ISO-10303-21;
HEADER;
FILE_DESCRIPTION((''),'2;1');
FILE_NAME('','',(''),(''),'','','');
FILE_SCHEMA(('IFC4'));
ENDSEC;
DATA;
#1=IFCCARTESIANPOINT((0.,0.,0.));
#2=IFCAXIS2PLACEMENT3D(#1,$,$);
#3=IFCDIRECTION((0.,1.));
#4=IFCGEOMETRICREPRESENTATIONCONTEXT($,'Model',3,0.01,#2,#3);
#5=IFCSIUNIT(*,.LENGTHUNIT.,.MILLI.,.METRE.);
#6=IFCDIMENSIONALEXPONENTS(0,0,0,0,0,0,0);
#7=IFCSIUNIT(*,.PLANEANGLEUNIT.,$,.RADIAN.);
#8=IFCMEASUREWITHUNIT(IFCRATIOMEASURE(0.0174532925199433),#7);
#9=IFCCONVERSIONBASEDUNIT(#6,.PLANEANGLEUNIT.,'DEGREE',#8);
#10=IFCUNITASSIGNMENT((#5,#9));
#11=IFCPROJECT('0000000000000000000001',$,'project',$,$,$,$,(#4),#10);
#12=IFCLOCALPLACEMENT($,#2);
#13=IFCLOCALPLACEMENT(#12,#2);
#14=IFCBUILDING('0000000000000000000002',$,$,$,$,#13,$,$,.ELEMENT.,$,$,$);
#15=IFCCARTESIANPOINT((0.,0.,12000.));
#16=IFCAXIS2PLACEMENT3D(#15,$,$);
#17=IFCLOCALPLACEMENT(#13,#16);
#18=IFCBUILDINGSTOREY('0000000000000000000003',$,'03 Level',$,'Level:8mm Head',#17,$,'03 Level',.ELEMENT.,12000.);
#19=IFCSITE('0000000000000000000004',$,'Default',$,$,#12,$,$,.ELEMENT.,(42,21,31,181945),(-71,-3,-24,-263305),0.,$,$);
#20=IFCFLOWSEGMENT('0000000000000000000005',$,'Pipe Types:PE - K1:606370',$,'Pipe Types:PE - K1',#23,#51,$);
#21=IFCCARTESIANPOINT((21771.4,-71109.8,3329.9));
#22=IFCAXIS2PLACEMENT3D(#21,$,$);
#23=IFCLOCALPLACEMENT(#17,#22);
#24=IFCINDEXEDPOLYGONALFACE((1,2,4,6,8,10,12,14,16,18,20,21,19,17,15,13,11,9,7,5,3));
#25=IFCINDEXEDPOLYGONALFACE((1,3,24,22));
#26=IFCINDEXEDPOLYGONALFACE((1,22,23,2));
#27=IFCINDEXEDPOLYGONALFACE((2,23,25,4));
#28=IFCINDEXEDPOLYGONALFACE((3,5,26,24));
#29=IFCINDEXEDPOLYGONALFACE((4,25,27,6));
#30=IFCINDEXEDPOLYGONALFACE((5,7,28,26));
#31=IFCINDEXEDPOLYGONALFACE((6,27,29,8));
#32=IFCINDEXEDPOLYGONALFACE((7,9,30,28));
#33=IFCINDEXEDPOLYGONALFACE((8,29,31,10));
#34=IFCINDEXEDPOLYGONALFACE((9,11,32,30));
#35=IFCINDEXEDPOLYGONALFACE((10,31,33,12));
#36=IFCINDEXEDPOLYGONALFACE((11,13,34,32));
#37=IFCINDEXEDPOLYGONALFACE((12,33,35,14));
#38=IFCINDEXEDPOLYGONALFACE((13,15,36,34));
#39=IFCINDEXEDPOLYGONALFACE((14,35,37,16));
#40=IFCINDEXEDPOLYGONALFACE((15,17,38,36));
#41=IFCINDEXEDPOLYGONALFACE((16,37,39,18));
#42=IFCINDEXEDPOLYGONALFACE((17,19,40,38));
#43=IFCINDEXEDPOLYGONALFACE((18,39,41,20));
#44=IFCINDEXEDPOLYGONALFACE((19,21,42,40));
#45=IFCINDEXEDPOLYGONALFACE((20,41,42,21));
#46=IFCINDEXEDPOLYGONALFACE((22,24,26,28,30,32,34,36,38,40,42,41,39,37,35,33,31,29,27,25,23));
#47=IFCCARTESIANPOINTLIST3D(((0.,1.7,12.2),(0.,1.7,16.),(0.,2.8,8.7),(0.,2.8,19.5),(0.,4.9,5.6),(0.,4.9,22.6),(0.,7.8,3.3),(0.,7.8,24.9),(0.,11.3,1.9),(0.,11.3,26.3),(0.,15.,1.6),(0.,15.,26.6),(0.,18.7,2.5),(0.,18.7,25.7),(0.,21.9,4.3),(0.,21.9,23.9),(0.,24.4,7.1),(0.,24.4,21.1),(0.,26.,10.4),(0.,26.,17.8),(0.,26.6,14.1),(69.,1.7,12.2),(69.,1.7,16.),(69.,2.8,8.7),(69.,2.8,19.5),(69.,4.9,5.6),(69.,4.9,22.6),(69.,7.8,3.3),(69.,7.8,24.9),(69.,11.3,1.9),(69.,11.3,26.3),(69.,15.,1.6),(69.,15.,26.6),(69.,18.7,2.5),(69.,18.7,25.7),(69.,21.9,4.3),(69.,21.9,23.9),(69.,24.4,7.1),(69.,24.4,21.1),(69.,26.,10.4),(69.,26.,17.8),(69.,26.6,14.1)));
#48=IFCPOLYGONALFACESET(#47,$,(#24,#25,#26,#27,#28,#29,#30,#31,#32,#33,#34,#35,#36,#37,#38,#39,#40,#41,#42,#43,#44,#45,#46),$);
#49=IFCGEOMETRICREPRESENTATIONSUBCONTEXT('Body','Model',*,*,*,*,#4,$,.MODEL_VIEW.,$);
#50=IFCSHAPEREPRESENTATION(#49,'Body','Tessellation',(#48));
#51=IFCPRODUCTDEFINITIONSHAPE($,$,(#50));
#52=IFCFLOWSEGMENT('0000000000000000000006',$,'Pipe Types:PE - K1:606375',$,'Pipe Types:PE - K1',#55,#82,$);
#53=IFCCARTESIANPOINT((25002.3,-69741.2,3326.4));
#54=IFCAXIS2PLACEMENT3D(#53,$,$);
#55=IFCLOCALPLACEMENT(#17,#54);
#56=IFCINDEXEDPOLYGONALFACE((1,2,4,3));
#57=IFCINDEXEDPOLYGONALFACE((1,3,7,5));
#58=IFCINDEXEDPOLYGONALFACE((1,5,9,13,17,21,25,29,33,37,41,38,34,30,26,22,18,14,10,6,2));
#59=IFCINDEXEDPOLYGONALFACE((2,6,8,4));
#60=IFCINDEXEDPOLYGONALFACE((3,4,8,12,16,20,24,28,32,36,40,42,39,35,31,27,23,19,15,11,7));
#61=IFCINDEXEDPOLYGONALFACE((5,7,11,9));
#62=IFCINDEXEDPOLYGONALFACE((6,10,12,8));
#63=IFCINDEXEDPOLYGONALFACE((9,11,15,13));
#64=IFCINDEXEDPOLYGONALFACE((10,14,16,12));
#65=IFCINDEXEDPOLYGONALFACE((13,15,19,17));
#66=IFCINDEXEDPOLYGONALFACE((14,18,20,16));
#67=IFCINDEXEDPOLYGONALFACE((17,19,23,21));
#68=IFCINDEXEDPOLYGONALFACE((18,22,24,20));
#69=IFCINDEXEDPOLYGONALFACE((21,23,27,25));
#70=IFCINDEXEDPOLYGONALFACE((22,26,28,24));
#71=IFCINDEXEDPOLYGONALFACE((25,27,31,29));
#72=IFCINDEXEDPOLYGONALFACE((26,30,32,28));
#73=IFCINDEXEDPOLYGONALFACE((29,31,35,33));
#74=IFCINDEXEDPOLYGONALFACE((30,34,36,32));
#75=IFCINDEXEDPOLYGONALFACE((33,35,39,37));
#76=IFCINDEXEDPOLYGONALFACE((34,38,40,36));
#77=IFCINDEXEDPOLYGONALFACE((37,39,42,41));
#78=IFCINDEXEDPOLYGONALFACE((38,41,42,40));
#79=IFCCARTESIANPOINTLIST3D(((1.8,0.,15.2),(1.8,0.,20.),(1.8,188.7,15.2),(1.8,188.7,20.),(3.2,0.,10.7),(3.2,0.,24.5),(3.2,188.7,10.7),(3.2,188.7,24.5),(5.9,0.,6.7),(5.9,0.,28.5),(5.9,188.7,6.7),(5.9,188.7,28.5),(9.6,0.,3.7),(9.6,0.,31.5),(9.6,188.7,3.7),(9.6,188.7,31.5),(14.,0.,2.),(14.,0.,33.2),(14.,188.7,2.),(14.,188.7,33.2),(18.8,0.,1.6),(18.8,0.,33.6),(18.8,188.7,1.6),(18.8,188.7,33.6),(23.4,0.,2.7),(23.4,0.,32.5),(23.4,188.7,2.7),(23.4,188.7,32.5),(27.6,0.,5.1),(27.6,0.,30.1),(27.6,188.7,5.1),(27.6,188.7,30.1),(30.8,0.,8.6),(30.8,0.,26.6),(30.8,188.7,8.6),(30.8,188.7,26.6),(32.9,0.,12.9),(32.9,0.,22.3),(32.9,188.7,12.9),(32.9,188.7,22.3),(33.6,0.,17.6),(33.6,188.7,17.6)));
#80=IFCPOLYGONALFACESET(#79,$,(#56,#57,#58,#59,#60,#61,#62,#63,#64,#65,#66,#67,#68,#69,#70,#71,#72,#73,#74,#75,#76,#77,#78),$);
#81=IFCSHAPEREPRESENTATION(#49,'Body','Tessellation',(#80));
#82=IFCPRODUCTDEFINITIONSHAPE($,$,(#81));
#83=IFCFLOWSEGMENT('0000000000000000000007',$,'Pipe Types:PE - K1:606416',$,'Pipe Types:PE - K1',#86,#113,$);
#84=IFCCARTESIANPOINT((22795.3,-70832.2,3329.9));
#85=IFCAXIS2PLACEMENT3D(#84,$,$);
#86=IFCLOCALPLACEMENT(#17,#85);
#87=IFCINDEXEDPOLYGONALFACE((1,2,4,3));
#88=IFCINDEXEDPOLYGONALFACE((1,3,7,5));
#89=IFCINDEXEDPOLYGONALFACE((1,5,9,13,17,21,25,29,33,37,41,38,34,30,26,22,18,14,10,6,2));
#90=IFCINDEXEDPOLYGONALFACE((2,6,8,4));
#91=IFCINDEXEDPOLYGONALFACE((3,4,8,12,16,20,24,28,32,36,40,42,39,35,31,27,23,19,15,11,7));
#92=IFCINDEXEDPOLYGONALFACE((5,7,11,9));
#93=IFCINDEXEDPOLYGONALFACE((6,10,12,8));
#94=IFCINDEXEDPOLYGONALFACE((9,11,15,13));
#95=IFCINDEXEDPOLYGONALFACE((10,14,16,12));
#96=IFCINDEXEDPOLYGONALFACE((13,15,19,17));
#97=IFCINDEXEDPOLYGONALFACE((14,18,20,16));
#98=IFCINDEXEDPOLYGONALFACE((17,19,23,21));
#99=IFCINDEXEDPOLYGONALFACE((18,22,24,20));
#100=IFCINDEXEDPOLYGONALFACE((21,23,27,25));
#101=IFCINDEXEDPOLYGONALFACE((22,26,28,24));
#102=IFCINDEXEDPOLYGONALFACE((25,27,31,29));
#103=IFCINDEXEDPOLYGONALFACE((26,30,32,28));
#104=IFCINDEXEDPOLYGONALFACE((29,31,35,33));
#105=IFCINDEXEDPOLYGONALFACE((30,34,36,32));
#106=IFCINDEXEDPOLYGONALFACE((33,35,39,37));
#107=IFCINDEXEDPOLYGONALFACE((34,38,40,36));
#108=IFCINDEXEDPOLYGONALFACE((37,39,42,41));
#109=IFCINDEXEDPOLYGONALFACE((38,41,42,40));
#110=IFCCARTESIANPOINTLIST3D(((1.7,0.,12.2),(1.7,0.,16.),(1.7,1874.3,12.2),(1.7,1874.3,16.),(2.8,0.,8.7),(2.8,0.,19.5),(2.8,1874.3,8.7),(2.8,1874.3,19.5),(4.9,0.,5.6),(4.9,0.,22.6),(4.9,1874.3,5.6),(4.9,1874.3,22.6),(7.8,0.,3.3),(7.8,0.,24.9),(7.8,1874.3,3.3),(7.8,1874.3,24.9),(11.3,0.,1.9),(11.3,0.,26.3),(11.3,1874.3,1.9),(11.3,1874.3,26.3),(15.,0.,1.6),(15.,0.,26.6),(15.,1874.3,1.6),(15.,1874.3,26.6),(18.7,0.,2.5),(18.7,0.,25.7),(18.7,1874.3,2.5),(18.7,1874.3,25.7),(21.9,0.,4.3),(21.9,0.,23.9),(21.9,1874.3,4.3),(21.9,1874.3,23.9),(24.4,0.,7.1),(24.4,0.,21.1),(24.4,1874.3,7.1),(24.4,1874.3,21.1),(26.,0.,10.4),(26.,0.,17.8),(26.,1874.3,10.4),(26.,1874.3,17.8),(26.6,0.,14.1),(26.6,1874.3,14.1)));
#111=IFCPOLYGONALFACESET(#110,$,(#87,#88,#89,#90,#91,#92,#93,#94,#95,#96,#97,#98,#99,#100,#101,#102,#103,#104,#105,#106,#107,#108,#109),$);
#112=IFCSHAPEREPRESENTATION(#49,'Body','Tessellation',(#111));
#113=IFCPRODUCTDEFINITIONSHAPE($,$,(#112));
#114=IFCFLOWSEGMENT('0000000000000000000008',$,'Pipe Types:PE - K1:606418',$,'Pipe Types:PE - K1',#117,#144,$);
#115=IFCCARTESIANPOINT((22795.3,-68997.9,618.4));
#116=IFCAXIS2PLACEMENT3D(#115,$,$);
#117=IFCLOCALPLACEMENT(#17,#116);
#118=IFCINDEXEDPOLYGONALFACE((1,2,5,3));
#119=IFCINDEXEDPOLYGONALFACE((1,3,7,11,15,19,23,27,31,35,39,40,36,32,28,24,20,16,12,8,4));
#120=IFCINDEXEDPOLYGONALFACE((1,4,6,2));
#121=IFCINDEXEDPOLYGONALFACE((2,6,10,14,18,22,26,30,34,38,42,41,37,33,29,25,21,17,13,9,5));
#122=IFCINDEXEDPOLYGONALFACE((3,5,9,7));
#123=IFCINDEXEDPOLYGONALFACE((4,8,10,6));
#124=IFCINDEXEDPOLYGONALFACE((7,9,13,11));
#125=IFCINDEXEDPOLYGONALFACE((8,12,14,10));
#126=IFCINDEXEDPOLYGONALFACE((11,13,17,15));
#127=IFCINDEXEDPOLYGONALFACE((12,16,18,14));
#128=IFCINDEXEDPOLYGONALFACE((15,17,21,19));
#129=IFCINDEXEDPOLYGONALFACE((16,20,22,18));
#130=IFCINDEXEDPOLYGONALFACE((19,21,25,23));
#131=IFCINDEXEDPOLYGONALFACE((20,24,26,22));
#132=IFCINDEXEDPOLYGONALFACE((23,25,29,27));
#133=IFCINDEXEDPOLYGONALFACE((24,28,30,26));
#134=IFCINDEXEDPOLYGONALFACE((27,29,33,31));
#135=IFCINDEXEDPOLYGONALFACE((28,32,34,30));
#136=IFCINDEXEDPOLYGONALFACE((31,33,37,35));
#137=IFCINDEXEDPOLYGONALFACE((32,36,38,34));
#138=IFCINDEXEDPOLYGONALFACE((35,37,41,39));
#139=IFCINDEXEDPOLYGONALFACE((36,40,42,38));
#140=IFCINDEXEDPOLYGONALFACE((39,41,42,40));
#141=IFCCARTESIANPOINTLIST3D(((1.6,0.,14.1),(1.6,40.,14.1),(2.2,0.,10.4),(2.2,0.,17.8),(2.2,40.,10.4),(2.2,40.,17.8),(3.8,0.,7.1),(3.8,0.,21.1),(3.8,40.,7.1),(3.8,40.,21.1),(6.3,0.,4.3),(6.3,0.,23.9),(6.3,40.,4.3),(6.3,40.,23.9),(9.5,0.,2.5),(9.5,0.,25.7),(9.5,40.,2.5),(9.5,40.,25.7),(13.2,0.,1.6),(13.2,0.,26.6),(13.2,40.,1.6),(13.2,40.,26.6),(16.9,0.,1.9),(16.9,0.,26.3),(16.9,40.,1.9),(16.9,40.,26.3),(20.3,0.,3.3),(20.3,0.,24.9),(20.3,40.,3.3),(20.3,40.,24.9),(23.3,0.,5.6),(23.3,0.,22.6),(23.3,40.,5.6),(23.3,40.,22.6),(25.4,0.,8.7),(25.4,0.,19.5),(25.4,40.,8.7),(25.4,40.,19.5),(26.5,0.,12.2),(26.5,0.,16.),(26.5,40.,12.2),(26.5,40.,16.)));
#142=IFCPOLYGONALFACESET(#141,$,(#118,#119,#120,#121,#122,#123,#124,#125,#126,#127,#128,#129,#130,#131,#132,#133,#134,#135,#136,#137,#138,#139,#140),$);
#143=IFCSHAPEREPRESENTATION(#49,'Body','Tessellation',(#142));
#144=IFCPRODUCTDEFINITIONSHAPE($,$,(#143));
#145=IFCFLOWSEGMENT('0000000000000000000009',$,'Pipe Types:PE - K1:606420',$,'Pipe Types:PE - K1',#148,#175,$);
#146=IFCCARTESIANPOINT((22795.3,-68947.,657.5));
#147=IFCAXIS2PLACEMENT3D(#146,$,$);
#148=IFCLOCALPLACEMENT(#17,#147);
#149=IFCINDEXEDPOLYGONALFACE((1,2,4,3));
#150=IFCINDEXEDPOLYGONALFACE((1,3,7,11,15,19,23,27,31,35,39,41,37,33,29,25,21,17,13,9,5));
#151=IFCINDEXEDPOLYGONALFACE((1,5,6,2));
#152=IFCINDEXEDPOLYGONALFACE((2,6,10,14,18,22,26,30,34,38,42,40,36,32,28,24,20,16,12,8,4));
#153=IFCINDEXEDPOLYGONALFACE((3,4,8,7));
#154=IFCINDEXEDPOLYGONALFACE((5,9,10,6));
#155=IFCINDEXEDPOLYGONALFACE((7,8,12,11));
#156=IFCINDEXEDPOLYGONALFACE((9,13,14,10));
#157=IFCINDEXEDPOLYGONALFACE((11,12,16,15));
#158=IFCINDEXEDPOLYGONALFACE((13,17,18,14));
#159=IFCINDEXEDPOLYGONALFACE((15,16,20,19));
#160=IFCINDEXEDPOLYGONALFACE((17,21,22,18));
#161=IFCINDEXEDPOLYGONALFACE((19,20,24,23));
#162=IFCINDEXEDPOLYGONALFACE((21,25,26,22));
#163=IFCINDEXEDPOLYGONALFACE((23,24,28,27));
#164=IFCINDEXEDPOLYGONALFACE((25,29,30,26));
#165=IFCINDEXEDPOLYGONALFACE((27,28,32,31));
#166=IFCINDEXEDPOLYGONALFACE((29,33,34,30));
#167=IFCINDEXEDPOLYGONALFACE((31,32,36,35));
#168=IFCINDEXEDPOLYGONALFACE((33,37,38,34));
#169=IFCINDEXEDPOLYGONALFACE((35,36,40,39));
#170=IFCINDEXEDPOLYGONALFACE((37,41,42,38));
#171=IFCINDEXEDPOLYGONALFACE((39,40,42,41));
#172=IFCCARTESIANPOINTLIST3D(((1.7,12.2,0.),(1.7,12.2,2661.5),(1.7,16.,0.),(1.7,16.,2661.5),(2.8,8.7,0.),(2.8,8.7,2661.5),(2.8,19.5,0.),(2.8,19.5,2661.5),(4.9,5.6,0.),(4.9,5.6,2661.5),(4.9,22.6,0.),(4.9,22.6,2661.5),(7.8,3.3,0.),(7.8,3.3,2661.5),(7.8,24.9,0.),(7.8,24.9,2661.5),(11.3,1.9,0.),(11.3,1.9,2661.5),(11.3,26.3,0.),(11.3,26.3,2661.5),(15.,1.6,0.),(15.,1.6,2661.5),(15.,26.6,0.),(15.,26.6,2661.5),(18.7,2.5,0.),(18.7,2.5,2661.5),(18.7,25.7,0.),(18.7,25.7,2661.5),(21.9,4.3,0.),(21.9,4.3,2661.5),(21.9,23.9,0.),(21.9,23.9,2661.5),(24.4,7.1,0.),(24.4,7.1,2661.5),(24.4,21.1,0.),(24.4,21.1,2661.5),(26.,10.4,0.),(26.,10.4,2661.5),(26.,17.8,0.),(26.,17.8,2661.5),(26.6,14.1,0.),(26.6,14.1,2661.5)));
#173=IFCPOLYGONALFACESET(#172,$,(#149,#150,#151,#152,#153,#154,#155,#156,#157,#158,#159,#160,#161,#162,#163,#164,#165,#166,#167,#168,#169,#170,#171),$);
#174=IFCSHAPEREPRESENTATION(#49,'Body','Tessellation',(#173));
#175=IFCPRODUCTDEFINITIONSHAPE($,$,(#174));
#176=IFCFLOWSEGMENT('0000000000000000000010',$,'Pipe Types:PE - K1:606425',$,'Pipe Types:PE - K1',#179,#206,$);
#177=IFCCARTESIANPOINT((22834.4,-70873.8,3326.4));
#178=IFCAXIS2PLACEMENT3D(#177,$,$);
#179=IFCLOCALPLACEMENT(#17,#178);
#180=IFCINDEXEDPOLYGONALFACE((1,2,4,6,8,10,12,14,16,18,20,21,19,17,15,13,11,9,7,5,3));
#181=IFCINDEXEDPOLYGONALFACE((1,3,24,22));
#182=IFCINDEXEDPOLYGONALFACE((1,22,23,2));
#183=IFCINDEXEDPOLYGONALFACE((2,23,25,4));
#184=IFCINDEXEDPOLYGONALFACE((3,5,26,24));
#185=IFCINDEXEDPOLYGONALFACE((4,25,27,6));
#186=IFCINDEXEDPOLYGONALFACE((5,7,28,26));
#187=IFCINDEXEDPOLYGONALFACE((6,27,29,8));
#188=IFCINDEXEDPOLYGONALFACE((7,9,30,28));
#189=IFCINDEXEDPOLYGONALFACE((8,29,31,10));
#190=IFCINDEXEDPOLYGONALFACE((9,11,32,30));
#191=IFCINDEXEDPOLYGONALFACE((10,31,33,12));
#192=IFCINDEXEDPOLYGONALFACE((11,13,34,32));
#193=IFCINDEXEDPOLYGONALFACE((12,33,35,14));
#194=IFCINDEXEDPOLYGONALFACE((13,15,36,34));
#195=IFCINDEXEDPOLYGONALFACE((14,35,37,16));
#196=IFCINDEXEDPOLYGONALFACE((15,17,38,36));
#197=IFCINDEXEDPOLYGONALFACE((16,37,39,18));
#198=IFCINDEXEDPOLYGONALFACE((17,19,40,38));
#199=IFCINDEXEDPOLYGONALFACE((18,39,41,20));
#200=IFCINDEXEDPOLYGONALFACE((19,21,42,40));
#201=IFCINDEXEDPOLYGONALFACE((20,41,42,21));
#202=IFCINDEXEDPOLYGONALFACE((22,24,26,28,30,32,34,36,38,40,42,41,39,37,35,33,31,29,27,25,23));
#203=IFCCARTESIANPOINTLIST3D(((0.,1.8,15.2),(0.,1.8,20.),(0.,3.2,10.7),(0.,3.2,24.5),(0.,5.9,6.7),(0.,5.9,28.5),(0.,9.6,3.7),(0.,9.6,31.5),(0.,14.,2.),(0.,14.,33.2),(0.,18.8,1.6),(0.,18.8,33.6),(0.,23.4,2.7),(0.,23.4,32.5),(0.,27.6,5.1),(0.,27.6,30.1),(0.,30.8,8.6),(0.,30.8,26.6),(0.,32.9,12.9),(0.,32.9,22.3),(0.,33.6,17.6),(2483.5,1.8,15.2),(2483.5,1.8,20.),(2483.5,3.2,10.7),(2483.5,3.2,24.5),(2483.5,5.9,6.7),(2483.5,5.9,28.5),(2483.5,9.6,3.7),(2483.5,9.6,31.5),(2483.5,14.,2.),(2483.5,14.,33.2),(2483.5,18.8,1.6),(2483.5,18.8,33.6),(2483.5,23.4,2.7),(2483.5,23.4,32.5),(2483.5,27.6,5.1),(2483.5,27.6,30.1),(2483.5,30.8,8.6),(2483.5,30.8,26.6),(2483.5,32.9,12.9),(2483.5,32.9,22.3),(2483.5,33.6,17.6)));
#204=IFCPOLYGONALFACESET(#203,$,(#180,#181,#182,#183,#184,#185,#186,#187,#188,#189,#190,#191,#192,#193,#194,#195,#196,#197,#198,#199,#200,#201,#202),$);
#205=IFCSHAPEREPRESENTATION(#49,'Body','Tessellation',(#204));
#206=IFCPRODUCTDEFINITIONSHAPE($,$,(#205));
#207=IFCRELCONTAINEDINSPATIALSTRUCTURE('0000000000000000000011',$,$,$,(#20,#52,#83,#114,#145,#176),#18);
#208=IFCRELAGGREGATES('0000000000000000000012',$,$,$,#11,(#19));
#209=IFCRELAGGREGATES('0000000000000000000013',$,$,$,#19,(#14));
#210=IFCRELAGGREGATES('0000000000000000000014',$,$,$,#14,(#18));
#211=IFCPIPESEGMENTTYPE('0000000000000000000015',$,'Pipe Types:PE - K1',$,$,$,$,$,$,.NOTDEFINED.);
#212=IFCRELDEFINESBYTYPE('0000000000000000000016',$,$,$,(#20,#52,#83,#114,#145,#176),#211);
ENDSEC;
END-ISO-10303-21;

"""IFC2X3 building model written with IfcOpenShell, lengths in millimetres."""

from ifc_helpers import new_model, entity, si_unit, converted_unit, direction, frame, frame_2d, origin, origin_2d_with_axis, place, context, subcontext, project, spatial, circle, extrude, type_object, element, save


model = new_model("IFC2X3")

# Units and contexts
model_context = context("Model", 3, precision=0.01, world=origin(), true_north=direction((0.0, 1.0)))
body_context = subcontext(model_context, "Body", "Model", "MODEL_VIEW")
ifc_project = project(units=[si_unit("LENGTHUNIT", "METRE", prefix="MILLI"), converted_unit("PLANEANGLEUNIT", "DEGREE", entity("IfcRatioMeasure", 0.0174532925199433), si_unit("PLANEANGLEUNIT", "RADIAN"), dimensions=[0, 0, 0, 0, 0, 0, 0])], contexts=[model_context])

# Site, building, storey
site_placement = place(None, origin())
site = spatial("IfcSite", under=ifc_project, at=site_placement, Name="Default", CompositionType="ELEMENT", RefLatitude=(42, 21, 31, 181945), RefLongitude=(-71, -3, -24, -263305), RefElevation=0.0)
building_placement = place(site_placement, origin())
building = spatial("IfcBuilding", under=site, at=building_placement, CompositionType="ELEMENT")
storey_placement = place(building_placement, frame((0.0, 0.0, 12000.0)))
storey = spatial("IfcBuildingStorey", under=building, at=storey_placement, Name="03 Level", ObjectType="Level:8mm Head", LongName="03 Level", CompositionType="ELEMENT", Elevation=12000.0)

# Flow segments
pipe_segment_type = type_object("IfcPipeSegmentType", Name="Pipe Types:PE - K1", PredefinedType="NOTDEFINED")
flow_segment_1_placement = place(storey_placement, frame((21771.4, -71109.8, 3329.9)))
element("IfcFlowSegment", 1, at=flow_segment_1_placement, inside=storey, type_object=pipe_segment_type, Name="Pipe Types:PE - K1:606370", ObjectType="Pipe Types:PE - K1", context=body_context, shape_type="SweptSolid", body=[
    extrude(circle(Radius=12.5, at=frame_2d((0.0, 0.0), x_axis=(1.0, 0.0))), frame((0.0, 14.1, 14.1), z_axis=(1.0, 0.0, 0.0), x_axis=(0.0, 1.0, 0.0)), (0.0, 0.0, 1.0), 69.0),
])
flow_segment_2_placement = place(storey_placement, frame((25002.3, -69741.2, 3326.4)))
element("IfcFlowSegment", 2, at=flow_segment_2_placement, inside=storey, type_object=pipe_segment_type, Name="Pipe Types:PE - K1:606375", ObjectType="Pipe Types:PE - K1", context=body_context, shape_type="SweptSolid", body=[
    extrude(circle(Radius=16.0, at=origin_2d_with_axis()), frame((17.6, 0.0, 17.6), z_axis=(0.0, 1.0, 0.0), x_axis=(1.0, 0.0, 0.0)), (0.0, 0.0, 1.0), 188.7),
])
flow_segment_3_placement = place(storey_placement, frame((22795.3, -70832.2, 3329.9)))
element("IfcFlowSegment", 3, at=flow_segment_3_placement, inside=storey, type_object=pipe_segment_type, Name="Pipe Types:PE - K1:606416", ObjectType="Pipe Types:PE - K1", context=body_context, shape_type="SweptSolid", body=[
    extrude(circle(Radius=12.5, at=origin_2d_with_axis()), frame((14.1, 0.0, 14.1), z_axis=(0.0, 1.0, 0.0), x_axis=(1.0, 0.0, 0.0)), (0.0, 0.0, 1.0), 1874.3),
])
flow_segment_4_placement = place(storey_placement, frame((22795.3, -68997.9, 618.4)))
element("IfcFlowSegment", 4, at=flow_segment_4_placement, inside=storey, type_object=pipe_segment_type, Name="Pipe Types:PE - K1:606418", ObjectType="Pipe Types:PE - K1", context=body_context, shape_type="SweptSolid", body=[
    extrude(circle(Radius=12.5, at=frame_2d((0.0, 0.0), x_axis=(1.0, 0.0))), frame((14.1, 0.0, 14.1), z_axis=(0.0, 1.0, 0.0), x_axis=(-1.0, 0.0, 0.0)), (0.0, 0.0, 1.0), 40.0),
])
flow_segment_5_placement = place(storey_placement, frame((22795.3, -68947.0, 657.5)))
element("IfcFlowSegment", 5, at=flow_segment_5_placement, inside=storey, type_object=pipe_segment_type, Name="Pipe Types:PE - K1:606420", ObjectType="Pipe Types:PE - K1", context=body_context, shape_type="SweptSolid", body=[
    extrude(circle(Radius=12.5, at=frame_2d((0.0, 0.0), x_axis=(1.0, 0.0))), frame((14.1, 14.1, 0.0)), (0.0, 0.0, 1.0), 2661.5),
])
flow_segment_6_placement = place(storey_placement, frame((22834.4, -70873.8, 3326.4)))
element("IfcFlowSegment", 6, at=flow_segment_6_placement, inside=storey, type_object=pipe_segment_type, Name="Pipe Types:PE - K1:606425", ObjectType="Pipe Types:PE - K1", context=body_context, shape_type="SweptSolid", body=[
    extrude(circle(Radius=16.0, at=origin_2d_with_axis()), frame((0.0, 17.6, 17.6), z_axis=(1.0, 0.0, 0.0), x_axis=(0.0, 1.0, 0.0)), (0.0, 0.0, 1.0), 2483.5),
])

save(model, "model.ifc")
